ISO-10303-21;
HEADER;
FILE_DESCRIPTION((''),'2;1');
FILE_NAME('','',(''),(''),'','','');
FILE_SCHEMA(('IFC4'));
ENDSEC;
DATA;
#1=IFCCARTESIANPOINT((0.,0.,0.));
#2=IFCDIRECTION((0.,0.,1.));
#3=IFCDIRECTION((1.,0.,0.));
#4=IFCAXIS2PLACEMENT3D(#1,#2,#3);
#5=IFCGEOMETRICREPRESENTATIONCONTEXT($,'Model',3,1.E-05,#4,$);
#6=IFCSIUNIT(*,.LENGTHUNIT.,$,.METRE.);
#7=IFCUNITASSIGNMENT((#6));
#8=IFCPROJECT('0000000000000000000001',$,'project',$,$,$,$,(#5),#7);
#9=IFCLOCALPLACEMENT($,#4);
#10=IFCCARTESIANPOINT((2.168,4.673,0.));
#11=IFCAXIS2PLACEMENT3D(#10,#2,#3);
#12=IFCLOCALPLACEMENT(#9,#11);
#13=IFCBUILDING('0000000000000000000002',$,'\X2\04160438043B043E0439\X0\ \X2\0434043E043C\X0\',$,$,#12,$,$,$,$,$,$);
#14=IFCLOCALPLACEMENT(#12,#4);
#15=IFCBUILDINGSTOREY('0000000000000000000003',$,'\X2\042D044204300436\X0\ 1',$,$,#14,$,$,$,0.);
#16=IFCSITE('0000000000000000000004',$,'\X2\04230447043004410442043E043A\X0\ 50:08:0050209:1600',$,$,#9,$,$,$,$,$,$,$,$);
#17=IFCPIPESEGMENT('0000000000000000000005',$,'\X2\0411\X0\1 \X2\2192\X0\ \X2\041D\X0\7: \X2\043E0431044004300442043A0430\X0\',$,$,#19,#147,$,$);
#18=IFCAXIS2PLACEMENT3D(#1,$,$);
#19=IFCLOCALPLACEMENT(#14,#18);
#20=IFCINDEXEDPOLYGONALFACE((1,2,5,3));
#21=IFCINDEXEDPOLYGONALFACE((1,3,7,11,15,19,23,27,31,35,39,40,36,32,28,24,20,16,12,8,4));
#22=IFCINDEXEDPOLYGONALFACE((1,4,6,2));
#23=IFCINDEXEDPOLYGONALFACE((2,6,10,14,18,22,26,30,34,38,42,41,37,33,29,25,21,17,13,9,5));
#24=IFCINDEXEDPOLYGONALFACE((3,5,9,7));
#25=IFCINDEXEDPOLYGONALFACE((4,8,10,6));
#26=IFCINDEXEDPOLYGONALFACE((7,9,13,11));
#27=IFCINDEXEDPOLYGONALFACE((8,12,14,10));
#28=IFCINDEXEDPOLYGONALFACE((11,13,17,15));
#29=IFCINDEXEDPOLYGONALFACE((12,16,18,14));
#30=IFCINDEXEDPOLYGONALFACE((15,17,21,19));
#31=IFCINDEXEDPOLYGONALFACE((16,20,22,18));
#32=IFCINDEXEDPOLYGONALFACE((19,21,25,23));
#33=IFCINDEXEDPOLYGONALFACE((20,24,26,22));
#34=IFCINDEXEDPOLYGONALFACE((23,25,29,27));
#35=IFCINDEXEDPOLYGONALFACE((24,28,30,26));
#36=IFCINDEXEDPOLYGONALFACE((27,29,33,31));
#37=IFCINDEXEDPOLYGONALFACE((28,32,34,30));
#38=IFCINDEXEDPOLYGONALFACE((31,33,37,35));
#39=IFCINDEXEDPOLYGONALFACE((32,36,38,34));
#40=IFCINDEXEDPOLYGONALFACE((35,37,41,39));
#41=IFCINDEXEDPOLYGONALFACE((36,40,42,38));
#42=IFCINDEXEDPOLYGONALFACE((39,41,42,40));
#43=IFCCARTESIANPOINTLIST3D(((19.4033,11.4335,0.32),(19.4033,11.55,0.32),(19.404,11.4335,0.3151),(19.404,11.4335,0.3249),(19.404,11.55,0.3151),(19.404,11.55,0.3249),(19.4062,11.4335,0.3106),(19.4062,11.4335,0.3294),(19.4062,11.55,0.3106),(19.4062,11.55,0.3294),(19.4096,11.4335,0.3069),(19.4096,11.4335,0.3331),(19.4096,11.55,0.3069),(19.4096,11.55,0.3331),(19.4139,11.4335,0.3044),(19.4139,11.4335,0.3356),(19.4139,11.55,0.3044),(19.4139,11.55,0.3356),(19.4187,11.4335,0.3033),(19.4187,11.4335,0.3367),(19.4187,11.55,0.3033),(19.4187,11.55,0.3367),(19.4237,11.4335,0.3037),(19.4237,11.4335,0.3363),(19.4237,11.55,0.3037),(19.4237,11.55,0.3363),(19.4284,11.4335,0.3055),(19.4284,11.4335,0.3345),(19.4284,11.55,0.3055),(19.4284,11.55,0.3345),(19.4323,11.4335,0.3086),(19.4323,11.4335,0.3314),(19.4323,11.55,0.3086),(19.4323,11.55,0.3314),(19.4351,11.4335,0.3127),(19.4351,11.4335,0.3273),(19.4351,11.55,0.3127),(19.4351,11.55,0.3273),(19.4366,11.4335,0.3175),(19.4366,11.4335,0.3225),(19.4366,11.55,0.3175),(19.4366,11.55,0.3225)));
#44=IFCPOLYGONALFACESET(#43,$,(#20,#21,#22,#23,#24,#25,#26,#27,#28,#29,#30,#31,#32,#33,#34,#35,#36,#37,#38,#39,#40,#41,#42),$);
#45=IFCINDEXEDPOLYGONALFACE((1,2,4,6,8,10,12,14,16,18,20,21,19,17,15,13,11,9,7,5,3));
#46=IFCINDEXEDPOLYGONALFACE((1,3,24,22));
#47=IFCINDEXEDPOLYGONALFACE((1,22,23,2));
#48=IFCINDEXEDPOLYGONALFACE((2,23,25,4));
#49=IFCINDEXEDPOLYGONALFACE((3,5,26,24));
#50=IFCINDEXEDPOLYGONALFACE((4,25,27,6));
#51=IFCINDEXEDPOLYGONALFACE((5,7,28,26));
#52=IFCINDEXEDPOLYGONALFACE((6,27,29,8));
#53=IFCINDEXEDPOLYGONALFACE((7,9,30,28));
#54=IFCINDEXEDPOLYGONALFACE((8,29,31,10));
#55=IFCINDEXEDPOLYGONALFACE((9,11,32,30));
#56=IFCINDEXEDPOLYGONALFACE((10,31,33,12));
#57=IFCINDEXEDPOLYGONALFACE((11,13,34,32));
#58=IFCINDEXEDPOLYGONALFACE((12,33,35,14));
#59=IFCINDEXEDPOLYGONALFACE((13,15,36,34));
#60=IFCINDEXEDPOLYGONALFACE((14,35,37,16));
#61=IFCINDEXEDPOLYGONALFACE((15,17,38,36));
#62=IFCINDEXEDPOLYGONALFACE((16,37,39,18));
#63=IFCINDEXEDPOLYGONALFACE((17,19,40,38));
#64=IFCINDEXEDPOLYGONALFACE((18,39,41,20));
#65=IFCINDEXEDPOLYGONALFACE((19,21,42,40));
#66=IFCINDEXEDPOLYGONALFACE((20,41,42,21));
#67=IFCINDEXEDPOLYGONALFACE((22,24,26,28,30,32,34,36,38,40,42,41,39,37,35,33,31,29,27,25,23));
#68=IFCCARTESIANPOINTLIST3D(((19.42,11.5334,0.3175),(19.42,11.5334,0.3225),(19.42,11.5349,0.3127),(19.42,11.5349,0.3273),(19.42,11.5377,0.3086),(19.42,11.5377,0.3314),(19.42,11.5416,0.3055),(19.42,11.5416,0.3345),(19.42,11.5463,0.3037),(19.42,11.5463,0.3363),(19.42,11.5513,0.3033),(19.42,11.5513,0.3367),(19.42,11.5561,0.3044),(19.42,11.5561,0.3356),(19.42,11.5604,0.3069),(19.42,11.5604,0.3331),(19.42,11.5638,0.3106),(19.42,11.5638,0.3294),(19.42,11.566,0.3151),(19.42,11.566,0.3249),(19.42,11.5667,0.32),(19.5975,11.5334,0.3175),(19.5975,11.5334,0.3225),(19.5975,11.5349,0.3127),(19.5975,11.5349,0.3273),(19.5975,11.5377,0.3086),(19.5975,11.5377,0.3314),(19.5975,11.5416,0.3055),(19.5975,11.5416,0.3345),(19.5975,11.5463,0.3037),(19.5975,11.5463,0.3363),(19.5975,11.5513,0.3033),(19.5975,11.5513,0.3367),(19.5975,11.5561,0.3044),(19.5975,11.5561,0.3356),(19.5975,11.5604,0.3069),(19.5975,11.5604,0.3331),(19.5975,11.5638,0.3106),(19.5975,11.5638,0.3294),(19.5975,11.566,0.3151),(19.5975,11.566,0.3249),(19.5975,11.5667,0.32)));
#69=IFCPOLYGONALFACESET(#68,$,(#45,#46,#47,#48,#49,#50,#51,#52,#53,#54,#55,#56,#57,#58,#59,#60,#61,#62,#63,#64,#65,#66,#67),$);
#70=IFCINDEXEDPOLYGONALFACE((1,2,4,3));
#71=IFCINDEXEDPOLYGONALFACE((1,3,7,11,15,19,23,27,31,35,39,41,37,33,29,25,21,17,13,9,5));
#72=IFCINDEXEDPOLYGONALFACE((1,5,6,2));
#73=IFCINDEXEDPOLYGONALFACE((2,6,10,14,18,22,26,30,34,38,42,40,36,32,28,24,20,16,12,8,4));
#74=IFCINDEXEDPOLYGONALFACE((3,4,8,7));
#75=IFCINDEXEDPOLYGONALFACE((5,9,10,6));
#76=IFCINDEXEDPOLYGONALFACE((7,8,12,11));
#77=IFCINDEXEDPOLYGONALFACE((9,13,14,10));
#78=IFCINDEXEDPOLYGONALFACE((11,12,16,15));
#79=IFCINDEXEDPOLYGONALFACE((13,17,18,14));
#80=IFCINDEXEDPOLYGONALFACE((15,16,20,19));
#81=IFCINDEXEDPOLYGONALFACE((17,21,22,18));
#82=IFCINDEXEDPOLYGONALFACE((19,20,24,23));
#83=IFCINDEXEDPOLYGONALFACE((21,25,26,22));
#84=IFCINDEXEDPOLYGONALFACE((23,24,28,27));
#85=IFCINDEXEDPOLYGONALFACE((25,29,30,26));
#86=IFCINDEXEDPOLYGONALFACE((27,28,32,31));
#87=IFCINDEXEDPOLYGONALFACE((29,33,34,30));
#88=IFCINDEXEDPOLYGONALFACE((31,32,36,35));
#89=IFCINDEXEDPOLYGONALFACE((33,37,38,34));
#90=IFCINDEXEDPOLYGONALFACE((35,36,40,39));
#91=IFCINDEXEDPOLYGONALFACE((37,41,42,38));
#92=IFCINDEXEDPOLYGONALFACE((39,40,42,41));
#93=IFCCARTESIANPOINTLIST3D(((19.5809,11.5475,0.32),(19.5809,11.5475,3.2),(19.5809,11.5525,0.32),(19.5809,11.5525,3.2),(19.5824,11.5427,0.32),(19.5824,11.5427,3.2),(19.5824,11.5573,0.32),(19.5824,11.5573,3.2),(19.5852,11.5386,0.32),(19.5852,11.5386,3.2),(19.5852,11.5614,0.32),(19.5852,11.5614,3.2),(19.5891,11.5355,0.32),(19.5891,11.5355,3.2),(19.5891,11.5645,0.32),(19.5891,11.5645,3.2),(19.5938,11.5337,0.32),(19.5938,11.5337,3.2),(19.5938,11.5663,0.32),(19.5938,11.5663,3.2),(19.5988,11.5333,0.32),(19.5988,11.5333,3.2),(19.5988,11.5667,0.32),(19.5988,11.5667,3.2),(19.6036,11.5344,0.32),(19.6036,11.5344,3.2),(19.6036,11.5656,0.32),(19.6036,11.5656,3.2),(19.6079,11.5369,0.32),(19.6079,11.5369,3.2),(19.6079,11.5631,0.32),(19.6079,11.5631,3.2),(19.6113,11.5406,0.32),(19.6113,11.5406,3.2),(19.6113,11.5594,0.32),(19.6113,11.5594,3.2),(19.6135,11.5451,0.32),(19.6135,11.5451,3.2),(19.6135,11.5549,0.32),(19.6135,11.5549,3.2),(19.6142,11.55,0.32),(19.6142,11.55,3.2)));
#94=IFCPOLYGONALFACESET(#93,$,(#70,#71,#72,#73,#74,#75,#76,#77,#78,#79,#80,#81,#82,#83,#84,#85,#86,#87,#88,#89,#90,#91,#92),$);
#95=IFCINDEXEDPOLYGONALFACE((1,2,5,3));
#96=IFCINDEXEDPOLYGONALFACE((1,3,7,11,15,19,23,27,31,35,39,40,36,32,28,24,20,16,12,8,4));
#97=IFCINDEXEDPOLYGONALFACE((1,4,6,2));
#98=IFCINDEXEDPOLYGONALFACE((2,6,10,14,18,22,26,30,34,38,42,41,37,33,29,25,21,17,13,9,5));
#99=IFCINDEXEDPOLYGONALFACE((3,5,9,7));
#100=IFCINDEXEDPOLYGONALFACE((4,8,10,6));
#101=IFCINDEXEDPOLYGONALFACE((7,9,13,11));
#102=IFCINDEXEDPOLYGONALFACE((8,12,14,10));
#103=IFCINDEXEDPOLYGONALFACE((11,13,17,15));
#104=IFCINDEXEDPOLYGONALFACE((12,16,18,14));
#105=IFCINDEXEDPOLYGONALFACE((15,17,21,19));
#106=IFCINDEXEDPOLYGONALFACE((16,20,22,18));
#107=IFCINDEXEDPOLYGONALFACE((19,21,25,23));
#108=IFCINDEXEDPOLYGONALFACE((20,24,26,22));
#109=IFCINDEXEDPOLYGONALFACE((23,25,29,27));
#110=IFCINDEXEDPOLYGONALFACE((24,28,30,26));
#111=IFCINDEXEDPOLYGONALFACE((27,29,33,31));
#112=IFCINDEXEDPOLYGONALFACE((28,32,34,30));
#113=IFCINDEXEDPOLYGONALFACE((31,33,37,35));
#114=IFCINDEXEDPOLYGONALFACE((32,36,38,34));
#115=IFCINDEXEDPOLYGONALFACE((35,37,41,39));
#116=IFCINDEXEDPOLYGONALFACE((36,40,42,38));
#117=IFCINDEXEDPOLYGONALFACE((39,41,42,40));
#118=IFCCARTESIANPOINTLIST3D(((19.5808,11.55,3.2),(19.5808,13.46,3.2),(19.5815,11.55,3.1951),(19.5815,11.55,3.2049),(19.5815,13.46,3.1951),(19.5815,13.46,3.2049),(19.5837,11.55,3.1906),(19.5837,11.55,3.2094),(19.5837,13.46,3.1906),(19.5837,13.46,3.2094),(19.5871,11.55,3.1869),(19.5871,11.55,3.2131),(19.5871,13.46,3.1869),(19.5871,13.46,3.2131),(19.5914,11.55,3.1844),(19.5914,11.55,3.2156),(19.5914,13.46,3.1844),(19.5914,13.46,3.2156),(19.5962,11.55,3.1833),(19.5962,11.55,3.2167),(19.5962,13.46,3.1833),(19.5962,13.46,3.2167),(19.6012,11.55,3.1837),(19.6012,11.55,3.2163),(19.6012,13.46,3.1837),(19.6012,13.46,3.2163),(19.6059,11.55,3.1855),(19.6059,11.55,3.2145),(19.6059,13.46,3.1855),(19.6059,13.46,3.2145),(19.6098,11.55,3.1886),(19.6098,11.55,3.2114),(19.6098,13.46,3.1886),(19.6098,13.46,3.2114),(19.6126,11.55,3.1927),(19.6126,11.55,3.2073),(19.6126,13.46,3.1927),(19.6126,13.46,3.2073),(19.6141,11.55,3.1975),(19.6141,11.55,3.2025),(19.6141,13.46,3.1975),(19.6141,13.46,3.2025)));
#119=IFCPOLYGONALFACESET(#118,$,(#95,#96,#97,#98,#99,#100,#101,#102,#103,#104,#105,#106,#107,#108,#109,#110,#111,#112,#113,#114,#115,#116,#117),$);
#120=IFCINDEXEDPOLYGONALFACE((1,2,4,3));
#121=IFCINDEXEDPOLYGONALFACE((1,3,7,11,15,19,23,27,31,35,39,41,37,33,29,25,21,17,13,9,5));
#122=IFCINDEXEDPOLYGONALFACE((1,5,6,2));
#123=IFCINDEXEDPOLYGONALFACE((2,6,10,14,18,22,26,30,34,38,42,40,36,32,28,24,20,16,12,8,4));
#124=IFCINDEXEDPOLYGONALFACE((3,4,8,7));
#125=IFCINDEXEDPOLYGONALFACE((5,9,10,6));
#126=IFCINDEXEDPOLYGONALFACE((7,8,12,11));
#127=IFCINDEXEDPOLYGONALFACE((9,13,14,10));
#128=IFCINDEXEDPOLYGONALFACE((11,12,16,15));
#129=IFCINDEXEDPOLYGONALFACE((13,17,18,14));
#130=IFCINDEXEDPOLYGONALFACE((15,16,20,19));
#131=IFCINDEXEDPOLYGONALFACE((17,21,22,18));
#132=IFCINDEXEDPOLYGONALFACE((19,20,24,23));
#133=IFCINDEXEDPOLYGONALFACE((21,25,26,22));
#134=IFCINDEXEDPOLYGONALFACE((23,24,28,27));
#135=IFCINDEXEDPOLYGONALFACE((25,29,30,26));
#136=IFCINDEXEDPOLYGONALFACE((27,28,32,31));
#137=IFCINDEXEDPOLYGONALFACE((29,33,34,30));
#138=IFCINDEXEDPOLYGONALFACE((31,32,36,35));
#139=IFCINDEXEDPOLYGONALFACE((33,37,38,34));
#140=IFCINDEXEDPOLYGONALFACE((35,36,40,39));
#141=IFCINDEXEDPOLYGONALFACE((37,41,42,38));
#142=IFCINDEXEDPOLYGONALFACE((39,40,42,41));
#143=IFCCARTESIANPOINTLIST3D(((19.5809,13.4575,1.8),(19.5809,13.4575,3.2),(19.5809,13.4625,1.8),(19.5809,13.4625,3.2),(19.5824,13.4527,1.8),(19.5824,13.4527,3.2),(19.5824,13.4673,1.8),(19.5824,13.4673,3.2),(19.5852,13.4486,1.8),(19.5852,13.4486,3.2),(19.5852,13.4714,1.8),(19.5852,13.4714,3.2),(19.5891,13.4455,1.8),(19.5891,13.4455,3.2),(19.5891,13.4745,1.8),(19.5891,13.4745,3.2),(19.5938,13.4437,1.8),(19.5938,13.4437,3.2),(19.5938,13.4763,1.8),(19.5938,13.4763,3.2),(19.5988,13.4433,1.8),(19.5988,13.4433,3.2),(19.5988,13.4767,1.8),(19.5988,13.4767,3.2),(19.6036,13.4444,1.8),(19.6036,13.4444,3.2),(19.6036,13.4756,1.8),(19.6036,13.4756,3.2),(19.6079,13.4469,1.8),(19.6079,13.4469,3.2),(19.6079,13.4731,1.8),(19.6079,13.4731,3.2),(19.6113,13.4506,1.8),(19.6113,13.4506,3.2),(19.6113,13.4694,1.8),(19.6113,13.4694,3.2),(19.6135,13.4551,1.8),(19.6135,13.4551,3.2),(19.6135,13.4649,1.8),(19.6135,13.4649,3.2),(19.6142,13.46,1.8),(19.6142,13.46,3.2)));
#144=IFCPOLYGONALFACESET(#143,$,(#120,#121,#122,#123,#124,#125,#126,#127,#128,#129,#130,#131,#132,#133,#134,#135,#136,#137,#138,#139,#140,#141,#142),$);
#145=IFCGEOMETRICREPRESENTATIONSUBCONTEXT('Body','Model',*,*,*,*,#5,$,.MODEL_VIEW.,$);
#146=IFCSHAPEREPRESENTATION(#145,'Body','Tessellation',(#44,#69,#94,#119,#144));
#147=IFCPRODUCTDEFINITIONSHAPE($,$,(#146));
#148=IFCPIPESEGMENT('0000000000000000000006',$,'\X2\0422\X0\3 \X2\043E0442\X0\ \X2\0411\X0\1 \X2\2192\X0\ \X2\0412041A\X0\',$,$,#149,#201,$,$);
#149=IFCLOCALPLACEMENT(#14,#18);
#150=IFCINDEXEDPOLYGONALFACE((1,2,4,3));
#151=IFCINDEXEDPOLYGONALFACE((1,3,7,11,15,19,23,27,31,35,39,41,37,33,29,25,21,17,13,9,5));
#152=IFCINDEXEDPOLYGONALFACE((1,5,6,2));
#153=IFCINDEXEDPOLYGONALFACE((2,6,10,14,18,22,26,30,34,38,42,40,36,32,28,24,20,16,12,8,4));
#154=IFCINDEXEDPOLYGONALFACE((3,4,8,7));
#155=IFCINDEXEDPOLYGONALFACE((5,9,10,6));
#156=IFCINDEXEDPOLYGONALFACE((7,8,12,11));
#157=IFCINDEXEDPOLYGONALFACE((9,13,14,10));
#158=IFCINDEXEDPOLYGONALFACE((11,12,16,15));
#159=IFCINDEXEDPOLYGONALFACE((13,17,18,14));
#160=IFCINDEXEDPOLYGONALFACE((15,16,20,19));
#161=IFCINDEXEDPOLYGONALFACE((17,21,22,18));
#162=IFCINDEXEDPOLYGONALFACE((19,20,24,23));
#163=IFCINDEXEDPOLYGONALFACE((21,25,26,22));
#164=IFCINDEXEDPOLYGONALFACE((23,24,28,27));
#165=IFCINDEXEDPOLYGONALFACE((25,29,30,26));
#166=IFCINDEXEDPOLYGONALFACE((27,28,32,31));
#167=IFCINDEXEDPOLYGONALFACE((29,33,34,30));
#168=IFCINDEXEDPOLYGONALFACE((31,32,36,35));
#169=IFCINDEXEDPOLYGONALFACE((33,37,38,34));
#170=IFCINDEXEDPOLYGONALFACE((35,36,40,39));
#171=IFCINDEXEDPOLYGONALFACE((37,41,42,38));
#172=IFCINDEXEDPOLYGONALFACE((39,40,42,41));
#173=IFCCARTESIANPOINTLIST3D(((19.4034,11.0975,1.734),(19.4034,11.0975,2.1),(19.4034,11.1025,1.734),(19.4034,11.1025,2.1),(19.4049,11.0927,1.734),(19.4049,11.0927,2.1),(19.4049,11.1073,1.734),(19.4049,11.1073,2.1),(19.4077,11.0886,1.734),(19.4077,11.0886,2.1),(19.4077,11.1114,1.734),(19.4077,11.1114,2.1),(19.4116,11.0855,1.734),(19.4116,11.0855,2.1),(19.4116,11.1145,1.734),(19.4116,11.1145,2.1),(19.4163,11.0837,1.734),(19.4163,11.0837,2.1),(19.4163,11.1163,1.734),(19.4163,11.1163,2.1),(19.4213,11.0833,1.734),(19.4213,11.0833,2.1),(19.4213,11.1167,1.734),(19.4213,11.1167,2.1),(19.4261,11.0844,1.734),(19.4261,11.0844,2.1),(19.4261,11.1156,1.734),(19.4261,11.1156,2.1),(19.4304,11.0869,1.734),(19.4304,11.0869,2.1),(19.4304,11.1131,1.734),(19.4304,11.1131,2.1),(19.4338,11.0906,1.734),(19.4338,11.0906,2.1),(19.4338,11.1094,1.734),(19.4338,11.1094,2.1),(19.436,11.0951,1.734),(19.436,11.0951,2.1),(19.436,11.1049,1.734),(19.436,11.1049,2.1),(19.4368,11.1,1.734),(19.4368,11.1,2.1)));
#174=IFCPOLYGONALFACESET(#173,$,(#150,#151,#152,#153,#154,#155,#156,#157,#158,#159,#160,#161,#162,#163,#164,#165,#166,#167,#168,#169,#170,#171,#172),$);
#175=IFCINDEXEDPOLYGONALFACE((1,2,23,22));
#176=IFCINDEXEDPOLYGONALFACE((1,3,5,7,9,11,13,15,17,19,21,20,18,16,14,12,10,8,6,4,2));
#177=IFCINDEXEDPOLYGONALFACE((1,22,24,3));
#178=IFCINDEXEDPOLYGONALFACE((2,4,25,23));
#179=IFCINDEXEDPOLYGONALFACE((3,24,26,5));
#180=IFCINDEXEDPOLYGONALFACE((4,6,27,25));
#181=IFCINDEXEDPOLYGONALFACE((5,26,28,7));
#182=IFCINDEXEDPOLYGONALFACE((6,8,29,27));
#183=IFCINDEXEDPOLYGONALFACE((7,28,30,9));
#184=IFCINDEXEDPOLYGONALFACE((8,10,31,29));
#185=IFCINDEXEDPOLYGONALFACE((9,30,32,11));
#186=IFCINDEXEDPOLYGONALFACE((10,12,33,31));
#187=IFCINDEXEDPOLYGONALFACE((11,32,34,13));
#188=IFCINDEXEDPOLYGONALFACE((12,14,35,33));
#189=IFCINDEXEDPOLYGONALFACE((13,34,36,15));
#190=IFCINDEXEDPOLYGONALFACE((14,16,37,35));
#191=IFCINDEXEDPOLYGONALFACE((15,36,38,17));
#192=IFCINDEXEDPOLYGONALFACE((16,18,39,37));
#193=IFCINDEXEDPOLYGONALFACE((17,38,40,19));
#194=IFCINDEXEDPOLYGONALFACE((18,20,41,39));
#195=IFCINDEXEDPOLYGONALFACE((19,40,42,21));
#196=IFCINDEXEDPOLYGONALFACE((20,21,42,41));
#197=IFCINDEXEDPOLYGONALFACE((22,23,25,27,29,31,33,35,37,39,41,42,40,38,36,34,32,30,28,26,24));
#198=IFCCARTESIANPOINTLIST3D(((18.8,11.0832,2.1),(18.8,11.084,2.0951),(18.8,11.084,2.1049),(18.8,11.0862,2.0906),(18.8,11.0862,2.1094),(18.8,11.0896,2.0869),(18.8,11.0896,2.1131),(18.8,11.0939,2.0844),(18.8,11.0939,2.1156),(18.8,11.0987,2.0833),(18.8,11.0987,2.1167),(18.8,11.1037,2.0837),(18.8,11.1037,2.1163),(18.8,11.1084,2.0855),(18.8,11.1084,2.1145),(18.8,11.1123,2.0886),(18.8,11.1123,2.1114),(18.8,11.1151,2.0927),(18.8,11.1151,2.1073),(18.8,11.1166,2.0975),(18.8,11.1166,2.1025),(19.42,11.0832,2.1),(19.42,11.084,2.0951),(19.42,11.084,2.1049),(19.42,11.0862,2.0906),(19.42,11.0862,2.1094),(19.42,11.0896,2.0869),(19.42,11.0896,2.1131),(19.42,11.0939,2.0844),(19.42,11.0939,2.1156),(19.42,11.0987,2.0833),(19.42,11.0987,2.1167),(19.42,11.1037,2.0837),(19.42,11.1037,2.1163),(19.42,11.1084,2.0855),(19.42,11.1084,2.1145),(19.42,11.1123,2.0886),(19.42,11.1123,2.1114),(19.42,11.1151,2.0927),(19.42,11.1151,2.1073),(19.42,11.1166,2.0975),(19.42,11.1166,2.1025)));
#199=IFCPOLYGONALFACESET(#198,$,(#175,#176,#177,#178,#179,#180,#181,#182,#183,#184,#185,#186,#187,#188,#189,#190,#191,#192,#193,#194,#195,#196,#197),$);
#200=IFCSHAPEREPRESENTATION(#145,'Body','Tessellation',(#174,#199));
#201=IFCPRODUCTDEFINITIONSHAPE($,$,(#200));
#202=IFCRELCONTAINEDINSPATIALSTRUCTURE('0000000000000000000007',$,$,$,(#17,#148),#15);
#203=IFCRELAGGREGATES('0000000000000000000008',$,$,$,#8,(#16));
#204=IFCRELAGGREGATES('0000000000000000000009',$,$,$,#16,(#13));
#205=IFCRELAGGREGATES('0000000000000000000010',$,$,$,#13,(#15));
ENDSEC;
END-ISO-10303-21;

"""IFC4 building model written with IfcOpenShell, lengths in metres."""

from ifc_helpers import new_model, si_unit, frame, origin_with_axes, origin_2d, place, context, subcontext, project, spatial, circle, extrude, element, save


model = new_model("IFC4")

# Units and contexts
model_context = context("Model", 3, precision=1e-05, world=origin_with_axes())
body_context = subcontext(model_context, "Body", "Model", "MODEL_VIEW")
ifc_project = project(units=[si_unit("LENGTHUNIT", "METRE")], contexts=[model_context])

# Site, building, storey
site_placement = place(None, origin_with_axes())
site = spatial("IfcSite", under=ifc_project, at=site_placement, Name="Участок 50:08:0050209:1600")
building_placement = place(site_placement, frame((2.168, 4.673, 0.0), z_axis=(0.0, 0.0, 1.0), x_axis=(1.0, 0.0, 0.0)))
building = spatial("IfcBuilding", under=site, at=building_placement, Name="Жилой дом")
storey_placement = place(building_placement, origin_with_axes())
storey = spatial("IfcBuildingStorey", under=building, at=storey_placement, Name="Этаж 1", Elevation=0.0)

# Pipe segments
pipe_segment_1_placement = place(storey_placement, origin_with_axes())
element("IfcPipeSegment", 1, at=pipe_segment_1_placement, inside=storey, Name="Б1 → Н7: обратка", context=body_context, shape_type="SweptSolid", body=[
    extrude(circle(Radius=0.0168, at=origin_2d()), frame((19.42, 11.4335, 0.32), z_axis=(0.0, 1.0, 0.0), x_axis=(-1.0, 0.0, 0.0)), (0.0, 0.0, 1.0), 0.1165),
    extrude(circle(Radius=0.0168, at=origin_2d()), frame((19.42, 11.55, 0.32), z_axis=(1.0, 0.0, 0.0), x_axis=(0.0, 1.0, 0.0)), (0.0, 0.0, 1.0), 0.1775),
    extrude(circle(Radius=0.0168, at=origin_2d()), frame((19.5975, 11.55, 0.32), z_axis=(0.0, 0.0, 1.0), x_axis=(1.0, 0.0, 0.0)), (0.0, 0.0, 1.0), 2.88),
    extrude(circle(Radius=0.0168, at=origin_2d()), frame((19.5975, 11.55, 3.2), z_axis=(0.0, 1.0, 0.0), x_axis=(-1.0, 0.0, 0.0)), (0.0, 0.0, 1.0), 1.91),
    extrude(circle(Radius=0.0168, at=origin_2d()), frame((19.5975, 13.46, 3.2), z_axis=(0.0, 0.0, -1.0), x_axis=(1.0, 0.0, 0.0)), (0.0, 0.0, 1.0), 1.4),
])
pipe_segment_2_placement = place(storey_placement, origin_with_axes())
element("IfcPipeSegment", 2, at=pipe_segment_2_placement, inside=storey, Name="Т3 от Б1 → ВК", context=body_context, shape_type="SweptSolid", body=[
    extrude(circle(Radius=0.0168, at=origin_2d()), frame((19.42, 11.1, 1.734), z_axis=(0.0, 0.0, 1.0), x_axis=(1.0, 0.0, 0.0)), (0.0, 0.0, 1.0), 0.366),
    extrude(circle(Radius=0.0168, at=origin_2d()), frame((19.42, 11.1, 2.1), z_axis=(-1.0, 0.0, 0.0), x_axis=(0.0, -1.0, 0.0)), (0.0, 0.0, 1.0), 0.62),
])

save(model, "model.ifc")
